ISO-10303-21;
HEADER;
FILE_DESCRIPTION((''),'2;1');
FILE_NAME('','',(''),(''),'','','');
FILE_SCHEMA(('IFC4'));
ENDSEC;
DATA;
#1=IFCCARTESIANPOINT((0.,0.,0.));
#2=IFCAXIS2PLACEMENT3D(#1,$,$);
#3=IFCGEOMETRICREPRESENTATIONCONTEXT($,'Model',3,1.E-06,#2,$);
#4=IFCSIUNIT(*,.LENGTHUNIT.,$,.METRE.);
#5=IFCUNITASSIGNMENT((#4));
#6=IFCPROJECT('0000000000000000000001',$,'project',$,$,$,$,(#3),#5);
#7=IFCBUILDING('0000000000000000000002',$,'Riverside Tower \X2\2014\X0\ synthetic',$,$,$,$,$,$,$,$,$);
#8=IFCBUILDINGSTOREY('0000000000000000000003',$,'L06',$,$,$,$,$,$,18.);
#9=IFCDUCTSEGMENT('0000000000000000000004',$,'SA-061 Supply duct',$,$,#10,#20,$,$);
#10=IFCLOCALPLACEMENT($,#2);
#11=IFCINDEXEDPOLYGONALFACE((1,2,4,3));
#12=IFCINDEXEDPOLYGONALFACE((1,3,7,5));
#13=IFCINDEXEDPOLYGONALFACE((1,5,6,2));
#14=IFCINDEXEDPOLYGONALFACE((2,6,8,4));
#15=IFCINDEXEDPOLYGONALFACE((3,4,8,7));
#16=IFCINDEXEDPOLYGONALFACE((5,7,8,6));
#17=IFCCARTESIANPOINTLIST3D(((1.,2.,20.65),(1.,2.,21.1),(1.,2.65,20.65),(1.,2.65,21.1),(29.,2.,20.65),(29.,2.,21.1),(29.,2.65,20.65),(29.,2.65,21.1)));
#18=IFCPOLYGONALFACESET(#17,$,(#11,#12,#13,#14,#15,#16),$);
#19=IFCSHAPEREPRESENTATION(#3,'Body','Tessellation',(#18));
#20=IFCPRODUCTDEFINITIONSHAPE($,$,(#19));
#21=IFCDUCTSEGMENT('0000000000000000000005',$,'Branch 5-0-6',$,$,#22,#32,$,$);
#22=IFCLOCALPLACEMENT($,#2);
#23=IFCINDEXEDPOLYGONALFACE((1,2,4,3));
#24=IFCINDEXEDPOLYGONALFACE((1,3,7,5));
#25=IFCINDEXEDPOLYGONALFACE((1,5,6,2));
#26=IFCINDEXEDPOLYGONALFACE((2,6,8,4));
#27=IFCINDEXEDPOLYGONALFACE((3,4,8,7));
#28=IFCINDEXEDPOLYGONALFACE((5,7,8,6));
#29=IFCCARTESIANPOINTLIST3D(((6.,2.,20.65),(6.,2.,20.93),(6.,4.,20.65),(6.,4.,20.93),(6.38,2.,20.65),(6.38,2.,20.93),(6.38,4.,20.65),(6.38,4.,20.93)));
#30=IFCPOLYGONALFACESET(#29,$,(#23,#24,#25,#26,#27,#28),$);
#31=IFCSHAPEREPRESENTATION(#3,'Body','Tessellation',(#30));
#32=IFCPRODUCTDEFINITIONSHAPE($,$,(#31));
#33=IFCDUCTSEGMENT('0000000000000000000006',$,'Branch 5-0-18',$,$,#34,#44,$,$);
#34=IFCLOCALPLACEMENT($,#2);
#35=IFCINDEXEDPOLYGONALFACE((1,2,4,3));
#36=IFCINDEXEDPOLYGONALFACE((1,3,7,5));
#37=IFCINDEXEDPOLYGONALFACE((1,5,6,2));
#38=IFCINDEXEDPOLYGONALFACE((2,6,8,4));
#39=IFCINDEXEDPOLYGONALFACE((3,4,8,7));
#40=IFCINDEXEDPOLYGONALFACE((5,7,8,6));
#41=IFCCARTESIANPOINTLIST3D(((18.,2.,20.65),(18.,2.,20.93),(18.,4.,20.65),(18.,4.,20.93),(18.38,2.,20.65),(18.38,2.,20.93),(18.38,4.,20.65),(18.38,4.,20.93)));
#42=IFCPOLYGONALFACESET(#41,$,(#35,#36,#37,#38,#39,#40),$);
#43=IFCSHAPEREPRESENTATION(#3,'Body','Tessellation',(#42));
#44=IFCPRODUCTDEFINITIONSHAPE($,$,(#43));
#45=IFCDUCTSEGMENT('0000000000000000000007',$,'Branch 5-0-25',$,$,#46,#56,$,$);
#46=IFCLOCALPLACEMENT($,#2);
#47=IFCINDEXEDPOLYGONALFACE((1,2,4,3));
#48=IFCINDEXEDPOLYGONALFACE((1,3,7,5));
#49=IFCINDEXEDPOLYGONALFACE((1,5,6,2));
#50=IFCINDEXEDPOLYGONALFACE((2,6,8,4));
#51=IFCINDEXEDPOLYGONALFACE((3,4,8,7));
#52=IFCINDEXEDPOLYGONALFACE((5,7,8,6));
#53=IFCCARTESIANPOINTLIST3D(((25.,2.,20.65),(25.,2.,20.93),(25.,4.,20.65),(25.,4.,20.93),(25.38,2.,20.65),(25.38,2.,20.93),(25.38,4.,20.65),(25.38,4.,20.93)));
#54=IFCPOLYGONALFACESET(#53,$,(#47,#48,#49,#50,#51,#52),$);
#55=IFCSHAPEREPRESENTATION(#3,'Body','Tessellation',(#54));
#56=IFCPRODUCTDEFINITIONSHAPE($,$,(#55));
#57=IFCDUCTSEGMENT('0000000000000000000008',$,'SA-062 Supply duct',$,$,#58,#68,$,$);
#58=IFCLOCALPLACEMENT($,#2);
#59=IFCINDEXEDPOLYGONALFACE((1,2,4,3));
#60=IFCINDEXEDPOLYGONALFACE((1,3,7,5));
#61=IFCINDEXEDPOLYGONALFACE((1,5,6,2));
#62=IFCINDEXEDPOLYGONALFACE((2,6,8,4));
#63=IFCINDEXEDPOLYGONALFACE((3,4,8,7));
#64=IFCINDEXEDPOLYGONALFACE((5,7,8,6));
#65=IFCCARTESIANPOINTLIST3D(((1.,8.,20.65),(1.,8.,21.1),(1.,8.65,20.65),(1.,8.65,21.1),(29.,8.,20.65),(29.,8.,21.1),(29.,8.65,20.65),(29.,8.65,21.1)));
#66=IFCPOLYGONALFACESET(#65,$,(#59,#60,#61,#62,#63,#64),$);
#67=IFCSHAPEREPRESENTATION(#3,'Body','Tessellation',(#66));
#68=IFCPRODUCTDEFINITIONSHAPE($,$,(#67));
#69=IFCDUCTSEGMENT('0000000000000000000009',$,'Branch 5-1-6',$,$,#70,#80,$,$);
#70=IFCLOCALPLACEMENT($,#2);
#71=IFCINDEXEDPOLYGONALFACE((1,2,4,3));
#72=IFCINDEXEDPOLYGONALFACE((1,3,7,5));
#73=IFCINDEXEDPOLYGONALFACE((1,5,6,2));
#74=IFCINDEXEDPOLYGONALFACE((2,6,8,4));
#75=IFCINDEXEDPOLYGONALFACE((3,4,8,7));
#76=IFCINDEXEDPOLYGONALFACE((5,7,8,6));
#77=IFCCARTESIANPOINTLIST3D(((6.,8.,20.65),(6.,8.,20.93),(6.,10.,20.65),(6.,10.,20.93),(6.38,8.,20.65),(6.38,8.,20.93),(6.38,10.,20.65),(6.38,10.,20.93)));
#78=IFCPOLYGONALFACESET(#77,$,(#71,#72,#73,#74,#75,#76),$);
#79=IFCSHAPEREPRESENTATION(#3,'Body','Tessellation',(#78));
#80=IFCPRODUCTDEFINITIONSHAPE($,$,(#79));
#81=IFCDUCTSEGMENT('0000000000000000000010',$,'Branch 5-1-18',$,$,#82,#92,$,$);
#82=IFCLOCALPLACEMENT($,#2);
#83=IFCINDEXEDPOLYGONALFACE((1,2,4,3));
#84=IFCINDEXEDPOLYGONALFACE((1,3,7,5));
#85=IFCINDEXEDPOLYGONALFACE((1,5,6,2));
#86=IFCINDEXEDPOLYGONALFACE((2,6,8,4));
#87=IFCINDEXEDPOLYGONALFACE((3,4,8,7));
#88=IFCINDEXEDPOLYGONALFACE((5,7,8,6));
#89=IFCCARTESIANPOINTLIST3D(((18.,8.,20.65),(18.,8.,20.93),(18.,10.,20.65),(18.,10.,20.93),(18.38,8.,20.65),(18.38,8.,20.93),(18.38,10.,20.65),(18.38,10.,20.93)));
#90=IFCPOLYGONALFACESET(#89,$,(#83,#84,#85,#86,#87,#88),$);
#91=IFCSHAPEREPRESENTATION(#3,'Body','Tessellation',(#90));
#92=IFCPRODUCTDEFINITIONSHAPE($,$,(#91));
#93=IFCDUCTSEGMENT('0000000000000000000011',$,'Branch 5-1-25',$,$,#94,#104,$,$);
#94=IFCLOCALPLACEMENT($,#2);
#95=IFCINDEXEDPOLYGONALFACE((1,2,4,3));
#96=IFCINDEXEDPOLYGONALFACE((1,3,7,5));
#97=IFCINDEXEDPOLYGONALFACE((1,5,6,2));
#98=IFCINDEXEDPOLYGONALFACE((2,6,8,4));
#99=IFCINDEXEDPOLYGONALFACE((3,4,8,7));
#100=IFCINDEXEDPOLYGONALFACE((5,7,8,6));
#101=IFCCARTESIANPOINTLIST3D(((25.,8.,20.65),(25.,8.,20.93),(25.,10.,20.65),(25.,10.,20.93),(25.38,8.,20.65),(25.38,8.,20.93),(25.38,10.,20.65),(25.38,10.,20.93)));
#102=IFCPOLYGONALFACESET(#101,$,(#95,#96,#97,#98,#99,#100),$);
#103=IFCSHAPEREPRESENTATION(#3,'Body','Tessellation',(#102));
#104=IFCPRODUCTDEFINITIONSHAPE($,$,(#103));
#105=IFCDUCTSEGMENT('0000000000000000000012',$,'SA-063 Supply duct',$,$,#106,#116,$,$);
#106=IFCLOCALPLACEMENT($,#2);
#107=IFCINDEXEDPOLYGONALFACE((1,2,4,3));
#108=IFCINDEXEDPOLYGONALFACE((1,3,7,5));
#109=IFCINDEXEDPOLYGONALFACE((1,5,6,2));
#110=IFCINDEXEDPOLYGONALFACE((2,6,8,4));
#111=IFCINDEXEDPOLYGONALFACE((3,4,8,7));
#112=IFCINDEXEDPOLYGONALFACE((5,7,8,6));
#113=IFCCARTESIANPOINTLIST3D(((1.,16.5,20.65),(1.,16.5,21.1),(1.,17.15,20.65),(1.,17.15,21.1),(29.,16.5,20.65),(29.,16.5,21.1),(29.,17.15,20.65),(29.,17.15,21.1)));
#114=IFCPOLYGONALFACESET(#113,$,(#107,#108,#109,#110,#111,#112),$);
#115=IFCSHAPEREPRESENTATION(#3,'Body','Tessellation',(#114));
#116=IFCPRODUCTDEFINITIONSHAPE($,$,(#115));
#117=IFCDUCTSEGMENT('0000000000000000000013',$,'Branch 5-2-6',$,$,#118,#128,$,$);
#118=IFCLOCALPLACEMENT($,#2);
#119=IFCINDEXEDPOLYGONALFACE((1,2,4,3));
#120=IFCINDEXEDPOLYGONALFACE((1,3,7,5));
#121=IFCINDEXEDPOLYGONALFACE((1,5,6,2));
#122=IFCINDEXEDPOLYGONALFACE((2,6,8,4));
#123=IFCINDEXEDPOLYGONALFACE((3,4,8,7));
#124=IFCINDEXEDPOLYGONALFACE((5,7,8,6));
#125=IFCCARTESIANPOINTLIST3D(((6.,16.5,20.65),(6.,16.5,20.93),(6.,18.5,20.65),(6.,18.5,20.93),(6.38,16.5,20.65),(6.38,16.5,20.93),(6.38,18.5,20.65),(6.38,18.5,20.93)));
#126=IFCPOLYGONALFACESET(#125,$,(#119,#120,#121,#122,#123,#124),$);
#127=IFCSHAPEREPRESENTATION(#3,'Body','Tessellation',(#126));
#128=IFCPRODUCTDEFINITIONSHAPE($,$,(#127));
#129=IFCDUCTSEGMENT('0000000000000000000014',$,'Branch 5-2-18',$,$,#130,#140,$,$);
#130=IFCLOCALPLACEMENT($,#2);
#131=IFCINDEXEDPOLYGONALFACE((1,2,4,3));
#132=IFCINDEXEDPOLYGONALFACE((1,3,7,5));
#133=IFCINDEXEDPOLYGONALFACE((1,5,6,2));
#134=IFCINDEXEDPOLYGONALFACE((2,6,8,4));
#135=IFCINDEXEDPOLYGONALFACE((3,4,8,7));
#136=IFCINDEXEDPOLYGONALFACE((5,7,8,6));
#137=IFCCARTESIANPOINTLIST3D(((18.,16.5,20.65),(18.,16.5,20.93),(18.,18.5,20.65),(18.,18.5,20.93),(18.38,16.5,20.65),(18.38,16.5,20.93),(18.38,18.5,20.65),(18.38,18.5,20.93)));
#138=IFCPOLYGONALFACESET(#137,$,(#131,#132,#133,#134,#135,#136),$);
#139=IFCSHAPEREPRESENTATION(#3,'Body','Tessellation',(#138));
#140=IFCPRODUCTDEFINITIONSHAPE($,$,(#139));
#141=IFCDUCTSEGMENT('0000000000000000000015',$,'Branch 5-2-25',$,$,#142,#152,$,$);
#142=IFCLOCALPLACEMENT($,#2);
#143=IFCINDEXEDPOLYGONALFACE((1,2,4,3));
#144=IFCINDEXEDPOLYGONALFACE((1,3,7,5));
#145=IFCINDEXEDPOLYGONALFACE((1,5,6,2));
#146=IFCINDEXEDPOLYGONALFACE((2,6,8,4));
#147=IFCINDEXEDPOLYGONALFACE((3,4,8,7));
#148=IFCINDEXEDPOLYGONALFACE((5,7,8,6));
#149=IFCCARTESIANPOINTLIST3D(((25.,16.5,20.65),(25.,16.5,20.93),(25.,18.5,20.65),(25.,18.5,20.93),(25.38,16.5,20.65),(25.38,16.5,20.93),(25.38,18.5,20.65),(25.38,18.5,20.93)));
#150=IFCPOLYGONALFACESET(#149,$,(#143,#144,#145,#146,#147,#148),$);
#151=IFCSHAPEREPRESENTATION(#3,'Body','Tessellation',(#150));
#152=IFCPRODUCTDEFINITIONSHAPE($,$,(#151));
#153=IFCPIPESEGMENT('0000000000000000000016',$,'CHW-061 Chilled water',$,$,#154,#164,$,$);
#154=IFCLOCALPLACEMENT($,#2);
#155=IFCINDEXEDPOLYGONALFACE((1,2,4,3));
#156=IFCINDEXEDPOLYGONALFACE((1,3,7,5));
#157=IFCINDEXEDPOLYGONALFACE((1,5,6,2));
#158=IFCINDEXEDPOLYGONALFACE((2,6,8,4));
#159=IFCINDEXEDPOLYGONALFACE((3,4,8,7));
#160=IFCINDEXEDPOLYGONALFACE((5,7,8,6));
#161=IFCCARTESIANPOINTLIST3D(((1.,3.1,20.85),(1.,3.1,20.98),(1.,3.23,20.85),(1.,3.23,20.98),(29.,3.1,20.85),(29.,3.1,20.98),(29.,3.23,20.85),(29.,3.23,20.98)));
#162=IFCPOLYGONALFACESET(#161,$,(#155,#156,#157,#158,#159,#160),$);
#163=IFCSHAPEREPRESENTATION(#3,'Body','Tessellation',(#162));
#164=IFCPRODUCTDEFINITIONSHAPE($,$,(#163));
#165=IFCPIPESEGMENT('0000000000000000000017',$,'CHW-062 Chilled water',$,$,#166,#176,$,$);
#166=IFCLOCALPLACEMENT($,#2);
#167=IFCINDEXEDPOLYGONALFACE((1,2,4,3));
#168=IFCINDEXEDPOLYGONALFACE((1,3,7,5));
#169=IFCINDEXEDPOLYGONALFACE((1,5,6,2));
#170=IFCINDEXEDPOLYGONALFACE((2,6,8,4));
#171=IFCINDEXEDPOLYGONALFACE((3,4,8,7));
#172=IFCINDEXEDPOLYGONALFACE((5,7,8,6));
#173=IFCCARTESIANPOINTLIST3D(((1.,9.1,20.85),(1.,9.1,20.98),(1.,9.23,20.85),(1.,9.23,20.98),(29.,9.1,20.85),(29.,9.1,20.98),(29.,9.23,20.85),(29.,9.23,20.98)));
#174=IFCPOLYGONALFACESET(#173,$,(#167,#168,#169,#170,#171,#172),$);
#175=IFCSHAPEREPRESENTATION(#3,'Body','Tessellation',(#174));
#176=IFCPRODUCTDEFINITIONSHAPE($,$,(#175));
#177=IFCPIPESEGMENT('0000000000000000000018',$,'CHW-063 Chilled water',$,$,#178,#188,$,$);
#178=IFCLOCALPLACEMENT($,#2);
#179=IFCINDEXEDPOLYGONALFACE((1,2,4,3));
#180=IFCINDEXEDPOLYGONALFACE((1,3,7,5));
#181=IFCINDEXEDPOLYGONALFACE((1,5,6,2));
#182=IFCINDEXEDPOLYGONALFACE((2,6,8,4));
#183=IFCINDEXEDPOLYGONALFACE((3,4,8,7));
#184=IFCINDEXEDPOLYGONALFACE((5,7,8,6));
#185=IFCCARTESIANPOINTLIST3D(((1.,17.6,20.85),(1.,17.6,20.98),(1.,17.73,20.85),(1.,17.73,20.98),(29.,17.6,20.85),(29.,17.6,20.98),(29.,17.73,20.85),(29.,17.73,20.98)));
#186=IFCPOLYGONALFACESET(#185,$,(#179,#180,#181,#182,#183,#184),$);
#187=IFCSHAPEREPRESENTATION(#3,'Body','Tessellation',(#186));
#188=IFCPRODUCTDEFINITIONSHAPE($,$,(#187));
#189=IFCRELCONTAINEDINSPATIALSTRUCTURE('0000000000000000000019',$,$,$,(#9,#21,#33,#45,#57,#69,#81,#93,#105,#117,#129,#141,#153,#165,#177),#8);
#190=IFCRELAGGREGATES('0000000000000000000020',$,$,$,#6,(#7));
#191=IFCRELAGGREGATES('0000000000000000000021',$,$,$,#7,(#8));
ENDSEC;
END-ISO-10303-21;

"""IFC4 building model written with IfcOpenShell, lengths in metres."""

from ifc_helpers import new_model, si_unit, frame, origin, place, context, project, spatial, rectangle, extrude, element, save


model = new_model("IFC4")

# Units and contexts
model_context = context("Model", 3, precision=1e-06, world=origin())
ifc_project = project(units=[si_unit("LENGTHUNIT", "METRE")], contexts=[model_context])

# Building, storey
building = spatial("IfcBuilding", under=ifc_project, Name="Riverside Tower — synthetic")
storey = spatial("IfcBuildingStorey", under=building, Name="L06", Elevation=18.0)

# Duct segments
duct_segment_1_placement = place(None, frame((15.0, 2.325, 20.65)))
element("IfcDuctSegment", 1, at=duct_segment_1_placement, inside=storey, Name="SA-061 Supply duct", context=model_context, shape_type="SweptSolid", body=[
    extrude(rectangle(XDim=28.0, YDim=0.65), origin(), (0.0, 0.0, 1.0), 0.45),
])
for number, where, name in (
    (2, (6.19, 3.0, 20.65), "Branch 5-0-6"),
    (3, (18.19, 3.0, 20.65), "Branch 5-0-18"),
    (4, (25.19, 3.0, 20.65), "Branch 5-0-25"),
):
    element("IfcDuctSegment", number, at=place(None, frame(where)), inside=storey, Name=name, context=model_context, shape_type="SweptSolid", body=[
        extrude(rectangle(XDim=0.38, YDim=2.0), origin(), (0.0, 0.0, 1.0), 0.28),
    ])
duct_segment_2_placement = place(None, frame((15.0, 8.325, 20.65)))
element("IfcDuctSegment", 5, at=duct_segment_2_placement, inside=storey, Name="SA-062 Supply duct", context=model_context, shape_type="SweptSolid", body=[
    extrude(rectangle(XDim=28.0, YDim=0.65), origin(), (0.0, 0.0, 1.0), 0.45),
])
for number, where, name in (
    (6, (6.19, 9.0, 20.65), "Branch 5-1-6"),
    (7, (18.19, 9.0, 20.65), "Branch 5-1-18"),
    (8, (25.19, 9.0, 20.65), "Branch 5-1-25"),
):
    element("IfcDuctSegment", number, at=place(None, frame(where)), inside=storey, Name=name, context=model_context, shape_type="SweptSolid", body=[
        extrude(rectangle(XDim=0.38, YDim=2.0), origin(), (0.0, 0.0, 1.0), 0.28),
    ])
duct_segment_3_placement = place(None, frame((15.0, 16.825, 20.65)))
element("IfcDuctSegment", 9, at=duct_segment_3_placement, inside=storey, Name="SA-063 Supply duct", context=model_context, shape_type="SweptSolid", body=[
    extrude(rectangle(XDim=28.0, YDim=0.65), origin(), (0.0, 0.0, 1.0), 0.45),
])
for number, where, name in (
    (10, (6.19, 17.5, 20.65), "Branch 5-2-6"),
    (11, (18.19, 17.5, 20.65), "Branch 5-2-18"),
    (12, (25.19, 17.5, 20.65), "Branch 5-2-25"),
):
    element("IfcDuctSegment", number, at=place(None, frame(where)), inside=storey, Name=name, context=model_context, shape_type="SweptSolid", body=[
        extrude(rectangle(XDim=0.38, YDim=2.0), origin(), (0.0, 0.0, 1.0), 0.28),
    ])

# Pipe segments
for number, where, name in (
    (13, (15.0, 3.165, 20.85), "CHW-061 Chilled water"),
    (14, (15.0, 9.165, 20.85), "CHW-062 Chilled water"),
    (15, (15.0, 17.665, 20.85), "CHW-063 Chilled water"),
):
    element("IfcPipeSegment", number, at=place(None, frame(where)), inside=storey, Name=name, context=model_context, shape_type="SweptSolid", body=[
        extrude(rectangle(XDim=28.0, YDim=0.13), origin(), (0.0, 0.0, 1.0), 0.13),
    ])

save(model, "model.ifc")
